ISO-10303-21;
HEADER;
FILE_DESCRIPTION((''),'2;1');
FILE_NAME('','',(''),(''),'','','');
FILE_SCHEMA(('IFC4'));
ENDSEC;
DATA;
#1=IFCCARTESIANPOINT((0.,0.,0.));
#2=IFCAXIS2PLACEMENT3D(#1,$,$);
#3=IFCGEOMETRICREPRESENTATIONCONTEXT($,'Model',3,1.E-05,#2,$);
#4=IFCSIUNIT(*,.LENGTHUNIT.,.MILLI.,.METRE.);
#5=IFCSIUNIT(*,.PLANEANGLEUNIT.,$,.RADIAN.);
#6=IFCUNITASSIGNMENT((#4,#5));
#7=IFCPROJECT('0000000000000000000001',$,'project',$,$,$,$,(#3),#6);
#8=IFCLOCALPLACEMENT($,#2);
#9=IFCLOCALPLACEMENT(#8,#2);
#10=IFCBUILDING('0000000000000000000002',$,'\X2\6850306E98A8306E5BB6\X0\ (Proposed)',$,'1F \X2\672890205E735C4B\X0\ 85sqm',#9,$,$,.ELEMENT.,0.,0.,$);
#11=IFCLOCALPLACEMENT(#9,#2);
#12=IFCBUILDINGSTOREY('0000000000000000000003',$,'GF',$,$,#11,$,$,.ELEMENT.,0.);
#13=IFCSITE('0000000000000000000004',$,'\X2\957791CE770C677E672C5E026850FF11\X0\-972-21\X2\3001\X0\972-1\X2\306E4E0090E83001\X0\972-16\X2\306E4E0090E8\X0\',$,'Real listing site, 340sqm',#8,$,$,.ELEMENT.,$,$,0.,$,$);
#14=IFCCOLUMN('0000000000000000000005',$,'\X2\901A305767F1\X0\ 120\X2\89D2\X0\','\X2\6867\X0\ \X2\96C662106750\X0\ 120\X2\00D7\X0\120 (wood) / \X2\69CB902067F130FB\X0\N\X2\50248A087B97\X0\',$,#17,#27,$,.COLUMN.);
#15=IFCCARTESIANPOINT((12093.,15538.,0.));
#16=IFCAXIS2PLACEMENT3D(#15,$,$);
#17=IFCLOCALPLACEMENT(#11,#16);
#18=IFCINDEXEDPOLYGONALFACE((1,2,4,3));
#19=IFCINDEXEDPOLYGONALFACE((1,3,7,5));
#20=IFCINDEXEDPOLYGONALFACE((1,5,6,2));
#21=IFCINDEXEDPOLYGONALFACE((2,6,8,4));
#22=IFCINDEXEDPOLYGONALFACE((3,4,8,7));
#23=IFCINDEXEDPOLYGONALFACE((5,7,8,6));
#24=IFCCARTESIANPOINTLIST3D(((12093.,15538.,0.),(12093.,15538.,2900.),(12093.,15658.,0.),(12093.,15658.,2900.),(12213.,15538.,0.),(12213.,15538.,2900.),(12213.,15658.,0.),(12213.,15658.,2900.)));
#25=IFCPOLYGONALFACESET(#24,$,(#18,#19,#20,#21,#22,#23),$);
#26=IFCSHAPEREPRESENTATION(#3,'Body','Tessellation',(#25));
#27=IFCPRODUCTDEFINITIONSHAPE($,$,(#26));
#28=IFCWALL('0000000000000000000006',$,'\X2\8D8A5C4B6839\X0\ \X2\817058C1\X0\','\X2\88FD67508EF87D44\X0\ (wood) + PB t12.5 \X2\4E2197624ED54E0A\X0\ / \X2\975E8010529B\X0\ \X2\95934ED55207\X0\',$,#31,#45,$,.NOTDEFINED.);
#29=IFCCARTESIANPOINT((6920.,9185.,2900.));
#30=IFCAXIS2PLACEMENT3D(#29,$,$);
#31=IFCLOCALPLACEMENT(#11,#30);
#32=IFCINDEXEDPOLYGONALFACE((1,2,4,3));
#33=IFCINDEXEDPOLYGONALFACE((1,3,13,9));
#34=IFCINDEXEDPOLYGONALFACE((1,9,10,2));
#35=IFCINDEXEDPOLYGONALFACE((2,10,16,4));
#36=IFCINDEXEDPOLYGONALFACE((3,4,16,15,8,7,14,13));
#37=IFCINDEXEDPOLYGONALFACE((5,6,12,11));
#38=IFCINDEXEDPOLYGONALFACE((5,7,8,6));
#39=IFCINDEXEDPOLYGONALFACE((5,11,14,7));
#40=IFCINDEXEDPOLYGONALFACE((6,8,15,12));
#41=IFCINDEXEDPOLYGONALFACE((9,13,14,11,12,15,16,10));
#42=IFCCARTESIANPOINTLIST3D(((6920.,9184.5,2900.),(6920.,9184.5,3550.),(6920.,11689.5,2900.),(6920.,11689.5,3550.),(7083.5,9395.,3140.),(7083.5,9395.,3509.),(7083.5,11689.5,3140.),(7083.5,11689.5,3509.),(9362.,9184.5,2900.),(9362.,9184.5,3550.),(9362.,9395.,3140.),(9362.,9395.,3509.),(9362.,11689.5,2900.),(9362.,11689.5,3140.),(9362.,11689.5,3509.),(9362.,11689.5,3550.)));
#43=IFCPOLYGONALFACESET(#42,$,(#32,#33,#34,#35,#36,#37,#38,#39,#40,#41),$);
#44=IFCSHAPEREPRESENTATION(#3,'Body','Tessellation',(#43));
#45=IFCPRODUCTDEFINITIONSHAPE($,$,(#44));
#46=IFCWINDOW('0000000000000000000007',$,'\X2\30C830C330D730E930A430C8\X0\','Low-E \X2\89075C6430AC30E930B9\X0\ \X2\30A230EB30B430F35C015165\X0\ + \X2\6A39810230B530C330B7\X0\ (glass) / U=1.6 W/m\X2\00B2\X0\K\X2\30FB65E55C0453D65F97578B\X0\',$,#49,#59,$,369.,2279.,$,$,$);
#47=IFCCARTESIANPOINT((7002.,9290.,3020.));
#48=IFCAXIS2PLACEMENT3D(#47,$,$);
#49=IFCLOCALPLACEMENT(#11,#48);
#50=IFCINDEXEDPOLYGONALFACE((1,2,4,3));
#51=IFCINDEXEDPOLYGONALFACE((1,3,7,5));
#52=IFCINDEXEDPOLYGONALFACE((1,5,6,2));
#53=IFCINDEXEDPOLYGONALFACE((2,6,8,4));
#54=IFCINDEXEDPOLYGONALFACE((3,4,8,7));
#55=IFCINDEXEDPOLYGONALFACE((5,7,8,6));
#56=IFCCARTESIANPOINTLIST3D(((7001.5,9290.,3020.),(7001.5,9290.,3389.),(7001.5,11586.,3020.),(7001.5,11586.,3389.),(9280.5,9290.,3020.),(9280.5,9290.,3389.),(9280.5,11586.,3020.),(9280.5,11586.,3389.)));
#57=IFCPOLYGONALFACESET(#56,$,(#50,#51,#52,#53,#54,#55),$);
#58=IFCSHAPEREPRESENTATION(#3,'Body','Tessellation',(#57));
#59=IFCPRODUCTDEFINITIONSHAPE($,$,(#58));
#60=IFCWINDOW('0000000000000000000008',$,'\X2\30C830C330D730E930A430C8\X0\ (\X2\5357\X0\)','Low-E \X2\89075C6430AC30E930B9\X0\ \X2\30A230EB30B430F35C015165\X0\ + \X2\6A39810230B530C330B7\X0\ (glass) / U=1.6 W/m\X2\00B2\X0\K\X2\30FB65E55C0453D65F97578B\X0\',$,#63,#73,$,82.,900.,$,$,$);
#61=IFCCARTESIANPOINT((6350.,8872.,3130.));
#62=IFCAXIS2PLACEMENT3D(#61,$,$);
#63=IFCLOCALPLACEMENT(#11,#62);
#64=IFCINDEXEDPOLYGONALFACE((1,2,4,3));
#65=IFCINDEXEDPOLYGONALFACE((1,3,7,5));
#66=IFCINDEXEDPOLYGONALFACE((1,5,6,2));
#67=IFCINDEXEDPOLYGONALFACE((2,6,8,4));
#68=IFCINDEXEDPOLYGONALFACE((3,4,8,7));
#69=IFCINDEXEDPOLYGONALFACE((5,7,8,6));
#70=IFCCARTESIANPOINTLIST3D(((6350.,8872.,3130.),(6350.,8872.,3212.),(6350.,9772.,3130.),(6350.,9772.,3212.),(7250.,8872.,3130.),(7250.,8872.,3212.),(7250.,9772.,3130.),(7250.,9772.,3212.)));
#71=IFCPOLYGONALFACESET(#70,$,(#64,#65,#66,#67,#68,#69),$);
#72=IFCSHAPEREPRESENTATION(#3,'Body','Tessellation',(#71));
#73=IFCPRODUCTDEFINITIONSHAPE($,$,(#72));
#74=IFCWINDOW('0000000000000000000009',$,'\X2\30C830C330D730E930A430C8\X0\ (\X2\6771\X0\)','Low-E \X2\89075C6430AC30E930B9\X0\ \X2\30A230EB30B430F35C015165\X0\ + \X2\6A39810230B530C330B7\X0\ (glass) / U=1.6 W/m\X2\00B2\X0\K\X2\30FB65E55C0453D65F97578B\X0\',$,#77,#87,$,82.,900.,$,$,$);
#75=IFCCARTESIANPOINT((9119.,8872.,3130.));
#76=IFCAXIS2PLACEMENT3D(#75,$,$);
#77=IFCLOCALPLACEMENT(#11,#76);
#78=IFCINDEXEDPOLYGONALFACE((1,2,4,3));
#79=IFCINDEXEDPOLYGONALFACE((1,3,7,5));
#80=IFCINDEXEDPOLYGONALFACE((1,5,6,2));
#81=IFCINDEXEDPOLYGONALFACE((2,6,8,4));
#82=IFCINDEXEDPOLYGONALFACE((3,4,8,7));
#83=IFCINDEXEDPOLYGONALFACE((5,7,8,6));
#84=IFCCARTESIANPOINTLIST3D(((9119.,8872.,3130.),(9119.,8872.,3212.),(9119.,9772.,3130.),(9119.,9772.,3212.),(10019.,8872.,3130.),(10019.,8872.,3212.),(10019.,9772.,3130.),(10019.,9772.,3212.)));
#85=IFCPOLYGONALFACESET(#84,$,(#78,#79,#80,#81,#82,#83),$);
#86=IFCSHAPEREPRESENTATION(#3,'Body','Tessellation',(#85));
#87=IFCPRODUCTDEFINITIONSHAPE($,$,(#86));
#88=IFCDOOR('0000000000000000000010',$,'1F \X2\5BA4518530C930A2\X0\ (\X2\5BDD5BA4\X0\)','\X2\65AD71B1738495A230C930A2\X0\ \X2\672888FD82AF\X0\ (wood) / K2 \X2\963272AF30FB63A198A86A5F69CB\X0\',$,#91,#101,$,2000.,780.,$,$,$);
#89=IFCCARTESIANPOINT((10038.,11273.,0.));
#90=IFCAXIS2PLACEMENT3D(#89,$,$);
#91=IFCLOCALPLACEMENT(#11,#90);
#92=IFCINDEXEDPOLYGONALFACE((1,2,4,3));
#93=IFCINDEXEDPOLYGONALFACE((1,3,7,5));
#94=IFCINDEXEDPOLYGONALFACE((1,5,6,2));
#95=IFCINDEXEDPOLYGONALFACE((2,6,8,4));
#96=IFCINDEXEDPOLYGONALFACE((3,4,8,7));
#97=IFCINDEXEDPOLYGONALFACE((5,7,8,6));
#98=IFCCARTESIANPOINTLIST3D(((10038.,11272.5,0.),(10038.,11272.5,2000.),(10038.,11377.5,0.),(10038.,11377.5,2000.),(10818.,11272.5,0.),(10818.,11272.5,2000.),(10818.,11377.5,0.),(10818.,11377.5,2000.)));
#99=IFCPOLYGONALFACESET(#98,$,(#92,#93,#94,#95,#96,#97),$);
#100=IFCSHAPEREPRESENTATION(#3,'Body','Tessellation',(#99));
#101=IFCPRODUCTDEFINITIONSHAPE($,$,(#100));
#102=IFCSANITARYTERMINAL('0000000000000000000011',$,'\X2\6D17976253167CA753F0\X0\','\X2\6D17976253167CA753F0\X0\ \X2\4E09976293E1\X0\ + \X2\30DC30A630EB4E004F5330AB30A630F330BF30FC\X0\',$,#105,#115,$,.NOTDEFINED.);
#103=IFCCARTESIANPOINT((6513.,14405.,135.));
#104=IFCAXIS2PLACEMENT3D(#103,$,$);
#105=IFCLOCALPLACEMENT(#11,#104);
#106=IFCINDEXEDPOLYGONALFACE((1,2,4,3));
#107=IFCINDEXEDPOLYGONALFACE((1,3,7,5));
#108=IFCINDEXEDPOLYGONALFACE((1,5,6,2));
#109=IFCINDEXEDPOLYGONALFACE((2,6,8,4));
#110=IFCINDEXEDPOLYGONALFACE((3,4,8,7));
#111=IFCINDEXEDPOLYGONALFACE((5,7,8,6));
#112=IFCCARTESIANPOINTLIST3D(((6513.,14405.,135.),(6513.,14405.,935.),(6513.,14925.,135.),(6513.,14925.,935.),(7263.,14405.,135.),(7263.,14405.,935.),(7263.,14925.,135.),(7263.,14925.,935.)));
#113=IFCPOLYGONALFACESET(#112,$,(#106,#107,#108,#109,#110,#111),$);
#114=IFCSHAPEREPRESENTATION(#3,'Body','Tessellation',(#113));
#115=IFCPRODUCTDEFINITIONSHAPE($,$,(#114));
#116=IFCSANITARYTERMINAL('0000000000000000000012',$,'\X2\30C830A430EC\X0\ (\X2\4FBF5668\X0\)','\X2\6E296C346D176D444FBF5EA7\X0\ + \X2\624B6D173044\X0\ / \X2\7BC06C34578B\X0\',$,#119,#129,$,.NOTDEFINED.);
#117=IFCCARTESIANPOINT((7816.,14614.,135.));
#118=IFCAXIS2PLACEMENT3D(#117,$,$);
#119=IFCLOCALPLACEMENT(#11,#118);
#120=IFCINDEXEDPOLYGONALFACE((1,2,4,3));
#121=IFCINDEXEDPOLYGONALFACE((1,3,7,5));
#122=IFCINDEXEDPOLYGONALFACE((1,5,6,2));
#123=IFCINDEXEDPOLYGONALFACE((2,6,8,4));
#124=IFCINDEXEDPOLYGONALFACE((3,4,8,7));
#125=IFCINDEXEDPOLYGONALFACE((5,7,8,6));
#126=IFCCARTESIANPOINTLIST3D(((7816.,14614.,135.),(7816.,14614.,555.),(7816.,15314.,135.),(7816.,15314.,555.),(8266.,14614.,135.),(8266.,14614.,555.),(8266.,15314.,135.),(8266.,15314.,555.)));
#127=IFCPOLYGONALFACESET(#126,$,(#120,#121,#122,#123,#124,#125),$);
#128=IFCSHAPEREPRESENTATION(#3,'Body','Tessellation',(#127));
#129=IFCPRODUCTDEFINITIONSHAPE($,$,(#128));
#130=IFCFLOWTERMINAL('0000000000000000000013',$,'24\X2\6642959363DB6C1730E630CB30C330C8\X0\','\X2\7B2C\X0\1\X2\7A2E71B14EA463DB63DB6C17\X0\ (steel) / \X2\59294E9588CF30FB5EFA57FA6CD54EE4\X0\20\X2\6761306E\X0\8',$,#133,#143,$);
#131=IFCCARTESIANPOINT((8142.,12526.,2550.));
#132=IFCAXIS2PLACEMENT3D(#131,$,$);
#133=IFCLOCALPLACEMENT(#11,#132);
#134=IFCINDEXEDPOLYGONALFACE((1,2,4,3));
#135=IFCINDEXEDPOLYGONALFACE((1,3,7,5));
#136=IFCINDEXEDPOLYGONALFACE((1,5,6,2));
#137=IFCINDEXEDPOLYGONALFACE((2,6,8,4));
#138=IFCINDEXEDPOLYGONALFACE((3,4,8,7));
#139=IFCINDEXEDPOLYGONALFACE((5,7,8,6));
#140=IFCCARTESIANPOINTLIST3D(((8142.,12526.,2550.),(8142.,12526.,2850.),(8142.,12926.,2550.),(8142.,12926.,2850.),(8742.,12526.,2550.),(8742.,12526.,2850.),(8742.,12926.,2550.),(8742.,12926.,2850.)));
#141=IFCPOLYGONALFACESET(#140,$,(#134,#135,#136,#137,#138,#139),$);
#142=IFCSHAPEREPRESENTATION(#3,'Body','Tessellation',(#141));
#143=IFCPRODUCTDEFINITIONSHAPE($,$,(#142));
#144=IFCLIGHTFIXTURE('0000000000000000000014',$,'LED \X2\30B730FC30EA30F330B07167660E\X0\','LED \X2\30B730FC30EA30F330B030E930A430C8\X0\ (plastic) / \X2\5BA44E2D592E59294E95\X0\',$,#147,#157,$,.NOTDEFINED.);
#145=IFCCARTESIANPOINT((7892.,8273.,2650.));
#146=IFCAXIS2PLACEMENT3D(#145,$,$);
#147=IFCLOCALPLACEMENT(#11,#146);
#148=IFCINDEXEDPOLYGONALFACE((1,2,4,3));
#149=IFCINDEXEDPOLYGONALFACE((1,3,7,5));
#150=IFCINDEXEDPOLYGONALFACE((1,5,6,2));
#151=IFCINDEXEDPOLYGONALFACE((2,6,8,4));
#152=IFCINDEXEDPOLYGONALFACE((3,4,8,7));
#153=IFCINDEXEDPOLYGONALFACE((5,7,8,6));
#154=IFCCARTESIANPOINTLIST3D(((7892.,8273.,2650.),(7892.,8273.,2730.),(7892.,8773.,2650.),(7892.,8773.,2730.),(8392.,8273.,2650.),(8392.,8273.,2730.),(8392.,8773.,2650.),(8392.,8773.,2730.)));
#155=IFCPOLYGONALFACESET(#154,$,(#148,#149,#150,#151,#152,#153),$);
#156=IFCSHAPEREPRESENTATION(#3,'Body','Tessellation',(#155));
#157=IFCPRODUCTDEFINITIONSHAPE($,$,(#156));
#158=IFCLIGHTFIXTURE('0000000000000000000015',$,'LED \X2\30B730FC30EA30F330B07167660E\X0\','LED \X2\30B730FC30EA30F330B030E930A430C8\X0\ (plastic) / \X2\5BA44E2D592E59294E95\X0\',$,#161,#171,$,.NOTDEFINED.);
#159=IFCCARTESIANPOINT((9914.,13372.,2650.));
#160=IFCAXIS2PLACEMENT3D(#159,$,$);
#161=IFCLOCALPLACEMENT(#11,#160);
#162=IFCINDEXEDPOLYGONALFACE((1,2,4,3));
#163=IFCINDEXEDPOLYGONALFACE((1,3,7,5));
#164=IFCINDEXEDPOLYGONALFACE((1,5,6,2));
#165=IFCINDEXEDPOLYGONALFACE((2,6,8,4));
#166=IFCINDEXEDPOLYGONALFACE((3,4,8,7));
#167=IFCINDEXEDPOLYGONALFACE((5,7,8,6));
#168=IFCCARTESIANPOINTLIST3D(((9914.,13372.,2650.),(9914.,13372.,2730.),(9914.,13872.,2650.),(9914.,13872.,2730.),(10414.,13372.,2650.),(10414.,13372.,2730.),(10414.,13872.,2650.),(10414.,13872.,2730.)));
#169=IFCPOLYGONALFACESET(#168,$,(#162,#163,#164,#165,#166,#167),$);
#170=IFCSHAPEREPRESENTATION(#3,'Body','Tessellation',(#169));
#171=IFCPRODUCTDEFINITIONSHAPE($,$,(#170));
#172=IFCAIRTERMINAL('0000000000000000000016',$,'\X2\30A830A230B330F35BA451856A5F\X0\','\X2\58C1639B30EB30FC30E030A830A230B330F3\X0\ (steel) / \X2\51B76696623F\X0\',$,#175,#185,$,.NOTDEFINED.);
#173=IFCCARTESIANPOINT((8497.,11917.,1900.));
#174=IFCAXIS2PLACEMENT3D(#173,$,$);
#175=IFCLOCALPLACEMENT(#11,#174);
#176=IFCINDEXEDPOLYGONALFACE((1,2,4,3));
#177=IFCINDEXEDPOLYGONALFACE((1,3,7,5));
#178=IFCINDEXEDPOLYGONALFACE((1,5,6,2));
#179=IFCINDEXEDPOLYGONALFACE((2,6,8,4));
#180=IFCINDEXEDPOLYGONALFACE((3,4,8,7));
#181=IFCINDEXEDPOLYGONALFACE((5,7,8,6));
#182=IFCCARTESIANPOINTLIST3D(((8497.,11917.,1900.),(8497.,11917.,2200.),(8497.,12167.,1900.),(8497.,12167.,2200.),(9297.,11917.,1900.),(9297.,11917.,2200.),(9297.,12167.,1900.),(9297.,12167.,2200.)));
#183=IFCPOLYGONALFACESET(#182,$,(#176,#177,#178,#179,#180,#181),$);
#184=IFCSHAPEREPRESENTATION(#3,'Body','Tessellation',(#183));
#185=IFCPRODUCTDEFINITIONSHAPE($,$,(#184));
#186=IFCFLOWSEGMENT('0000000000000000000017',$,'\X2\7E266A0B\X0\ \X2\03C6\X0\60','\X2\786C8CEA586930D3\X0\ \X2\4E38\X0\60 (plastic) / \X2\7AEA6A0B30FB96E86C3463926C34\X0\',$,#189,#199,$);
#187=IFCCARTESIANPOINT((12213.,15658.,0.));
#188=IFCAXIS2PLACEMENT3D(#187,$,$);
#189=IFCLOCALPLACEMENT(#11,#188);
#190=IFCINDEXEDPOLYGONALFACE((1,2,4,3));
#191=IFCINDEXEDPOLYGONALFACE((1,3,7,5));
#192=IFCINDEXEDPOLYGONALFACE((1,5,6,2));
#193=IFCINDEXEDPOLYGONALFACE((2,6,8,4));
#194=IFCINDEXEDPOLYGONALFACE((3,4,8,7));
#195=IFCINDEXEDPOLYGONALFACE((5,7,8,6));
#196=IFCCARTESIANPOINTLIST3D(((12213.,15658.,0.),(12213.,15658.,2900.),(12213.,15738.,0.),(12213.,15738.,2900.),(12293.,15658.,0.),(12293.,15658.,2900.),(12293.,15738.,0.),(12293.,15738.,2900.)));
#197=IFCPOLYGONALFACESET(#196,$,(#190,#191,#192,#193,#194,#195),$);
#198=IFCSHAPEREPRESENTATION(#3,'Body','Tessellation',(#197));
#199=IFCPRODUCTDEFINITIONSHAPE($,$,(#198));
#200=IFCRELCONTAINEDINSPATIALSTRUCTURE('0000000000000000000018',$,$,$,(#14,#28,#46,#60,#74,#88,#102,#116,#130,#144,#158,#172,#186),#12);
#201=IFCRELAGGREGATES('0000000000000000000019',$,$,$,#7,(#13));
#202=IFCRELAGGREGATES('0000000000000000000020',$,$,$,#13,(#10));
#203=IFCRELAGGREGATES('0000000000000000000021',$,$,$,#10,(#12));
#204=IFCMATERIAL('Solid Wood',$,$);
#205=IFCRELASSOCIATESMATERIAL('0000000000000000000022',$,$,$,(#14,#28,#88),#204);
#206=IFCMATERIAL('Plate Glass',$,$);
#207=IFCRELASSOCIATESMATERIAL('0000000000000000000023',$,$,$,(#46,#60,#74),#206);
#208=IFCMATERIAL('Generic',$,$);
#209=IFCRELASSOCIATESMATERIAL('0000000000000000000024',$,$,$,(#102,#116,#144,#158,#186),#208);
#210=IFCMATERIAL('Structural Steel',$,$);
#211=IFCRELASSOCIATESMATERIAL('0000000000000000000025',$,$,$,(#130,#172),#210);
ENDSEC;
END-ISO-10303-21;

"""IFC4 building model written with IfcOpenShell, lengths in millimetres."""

from ifc_helpers import new_model, si_unit, frame, frame_2d, origin, place, context, project, spatial, rectangle, extrude, material, element, fill, save


model = new_model("IFC4")

# Units and contexts
model_context = context("Model", 3, precision=1e-05, world=origin())
ifc_project = project(units=[si_unit("LENGTHUNIT", "METRE", prefix="MILLI"), si_unit("PLANEANGLEUNIT", "RADIAN")], contexts=[model_context])

# Site, building, storey
site_placement = place(None, origin())
site = spatial("IfcSite", under=ifc_project, at=site_placement, Name="長野県松本市桐１-972-21、972-1の一部、972-16の一部", ObjectType="Real listing site, 340sqm", CompositionType="ELEMENT", RefElevation=0.0)
building_placement = place(site_placement, origin())
building = spatial("IfcBuilding", under=site, at=building_placement, Name="桐の風の家 (Proposed)", ObjectType="1F 木造平屋 85sqm", CompositionType="ELEMENT", ElevationOfRefHeight=0.0, ElevationOfTerrain=0.0)
storey_placement = place(building_placement, origin())
storey = spatial("IfcBuildingStorey", under=building, at=storey_placement, Name="GF", CompositionType="ELEMENT", Elevation=0.0)

# Column
ifc_material_1 = material(Name="Solid Wood")
column_1_placement = place(storey_placement, frame((12093.0, 15538.0, 0.0)))
element("IfcColumn", 1, at=column_1_placement, inside=storey, material=ifc_material_1, Name="通し柱 120角", Description="桧 集成材 120×120 (wood) / 構造柱・N値計算", PredefinedType="COLUMN", context=model_context, shape_type="SweptSolid", body=[
    extrude(rectangle(XDim=120.0, YDim=120.0, at=frame_2d((60.0, 60.0))), frame((12093.0, 15538.0, 0.0)), (0.0, 0.0, 1.0), 2900.0),
])

# Wall, openings, windows
wall_1_placement = place(storey_placement, frame((6920.0, 9185.0, 2900.0)))
wall_1 = element("IfcWall", 2, at=wall_1_placement, inside=storey, material=ifc_material_1, Name="越屋根 腰壁", Description="製材軸組 (wood) + PB t12.5 両面仕上 / 非耐力 間仕切", PredefinedType="NOTDEFINED", context=model_context, shape_type="SweptSolid", body=[
    extrude(rectangle(XDim=2442.0, YDim=2505.0, at=frame_2d((1221.0, 1252.0))), frame((6920.0, 9185.0, 2900.0)), (0.0, 0.0, 1.0), 650.0),
])
opening_1_placement = place(storey_placement, frame((7002.0, 9290.0, 3020.0)))
opening_1 = element("IfcOpeningElement", 3, at=opening_1_placement, cuts=wall_1, PredefinedType="NOTDEFINED", context=model_context, shape_type="SweptSolid", body=[
    extrude(rectangle(XDim=2279.0, YDim=2296.0, at=frame_2d((1139.0, 1148.0))), frame((7002.0, 9290.0, 3020.0)), (0.0, 0.0, 1.0), 369.0),
])
opening_2_placement = place(storey_placement, frame((6350.0, 8872.0, 3130.0)))
opening_2 = element("IfcOpeningElement", 4, at=opening_2_placement, cuts=wall_1, PredefinedType="NOTDEFINED", context=model_context, shape_type="SweptSolid", body=[
    extrude(rectangle(XDim=900.0, YDim=900.0, at=frame_2d((450.0, 450.0))), frame((6350.0, 8872.0, 3130.0)), (0.0, 0.0, 1.0), 82.0),
])
opening_3_placement = place(storey_placement, frame((9119.0, 8872.0, 3130.0)))
opening_3 = element("IfcOpeningElement", 5, at=opening_3_placement, cuts=wall_1, PredefinedType="NOTDEFINED", context=model_context, shape_type="SweptSolid", body=[
    extrude(rectangle(XDim=900.0, YDim=900.0, at=frame_2d((450.0, 450.0))), frame((9119.0, 8872.0, 3130.0)), (0.0, 0.0, 1.0), 82.0),
])
ifc_material_2 = material(Name="Plate Glass")
window_1_placement = place(storey_placement, frame((7002.0, 9290.0, 3020.0)))
window_1 = element("IfcWindow", 6, at=window_1_placement, inside=storey, material=ifc_material_2, Name="トップライト", Description="Low-E 複層ガラス アルゴン封入 + 樹脂サッシ (glass) / U=1.6 W/m²K・日射取得型", OverallHeight=369.0, OverallWidth=2279.0, context=model_context, shape_type="SweptSolid", body=[
    extrude(rectangle(XDim=2279.0, YDim=2296.0, at=frame_2d((1139.0, 1148.0))), frame((7002.0, 9290.0, 3020.0)), (0.0, 0.0, 1.0), 369.0),
])
fill(opening_1, window_1)
window_2_placement = place(storey_placement, frame((6350.0, 8872.0, 3130.0)))
window_2 = element("IfcWindow", 7, at=window_2_placement, inside=storey, material=ifc_material_2, Name="トップライト (南)", Description="Low-E 複層ガラス アルゴン封入 + 樹脂サッシ (glass) / U=1.6 W/m²K・日射取得型", OverallHeight=82.0, OverallWidth=900.0, context=model_context, shape_type="SweptSolid", body=[
    extrude(rectangle(XDim=900.0, YDim=900.0, at=frame_2d((450.0, 450.0))), frame((6350.0, 8872.0, 3130.0)), (0.0, 0.0, 1.0), 82.0),
])
fill(opening_2, window_2)
window_3_placement = place(storey_placement, frame((9119.0, 8872.0, 3130.0)))
window_3 = element("IfcWindow", 8, at=window_3_placement, inside=storey, material=ifc_material_2, Name="トップライト (東)", Description="Low-E 複層ガラス アルゴン封入 + 樹脂サッシ (glass) / U=1.6 W/m²K・日射取得型", OverallHeight=82.0, OverallWidth=900.0, context=model_context, shape_type="SweptSolid", body=[
    extrude(rectangle(XDim=900.0, YDim=900.0, at=frame_2d((450.0, 450.0))), frame((9119.0, 8872.0, 3130.0)), (0.0, 0.0, 1.0), 82.0),
])
fill(opening_3, window_3)

# Door
door_placement = place(storey_placement, frame((10038.0, 11273.0, 0.0)))
element("IfcDoor", 9, at=door_placement, inside=storey, material=ifc_material_1, Name="1F 室内ドア (寝室)", Description="断熱玄関ドア 木製芯 (wood) / K2 防犯・採風機構", OverallHeight=2000.0, OverallWidth=780.0, context=model_context, shape_type="SweptSolid", body=[
    extrude(rectangle(XDim=780.0, YDim=105.0, at=frame_2d((390.0, 52.0))), frame((10038.0, 11273.0, 0.0)), (0.0, 0.0, 1.0), 2000.0),
])

# Shared definitions
ifc_material_3 = material(Name="Structural Steel")

# Sanitary terminals
ifc_material_4 = material(Name="Generic")
sanitary_terminal_1_placement = place(storey_placement, frame((6513.0, 14405.0, 135.0)))
element("IfcSanitaryTerminal", 10, at=sanitary_terminal_1_placement, inside=storey, material=ifc_material_4, Name="洗面化粧台", Description="洗面化粧台 三面鏡 + ボウル一体カウンター", PredefinedType="NOTDEFINED", context=model_context, shape_type="SweptSolid", body=[
    extrude(rectangle(XDim=750.0, YDim=520.0, at=frame_2d((375.0, 260.0))), frame((6513.0, 14405.0, 135.0)), (0.0, 0.0, 1.0), 800.0),
])
sanitary_terminal_2_placement = place(storey_placement, frame((7816.0, 14614.0, 135.0)))
element("IfcSanitaryTerminal", 11, at=sanitary_terminal_2_placement, inside=storey, material=ifc_material_4, Name="トイレ (便器)", Description="温水洗浄便座 + 手洗い / 節水型", PredefinedType="NOTDEFINED", context=model_context, shape_type="SweptSolid", body=[
    extrude(rectangle(XDim=450.0, YDim=700.0, at=frame_2d((225.0, 350.0))), frame((7816.0, 14614.0, 135.0)), (0.0, 0.0, 1.0), 420.0),
])

# Flow terminal
flow_terminal_placement = place(storey_placement, frame((8142.0, 12526.0, 2550.0)))
element("IfcFlowTerminal", 12, at=flow_terminal_placement, inside=storey, material=ifc_material_3, Name="24時間換気ユニット", Description="第1種熱交換換気 (steel) / 天井裏・建基法令20条の8", context=model_context, shape_type="SweptSolid", body=[
    extrude(rectangle(XDim=600.0, YDim=400.0, at=frame_2d((300.0, 200.0))), frame((8142.0, 12526.0, 2550.0)), (0.0, 0.0, 1.0), 300.0),
])

# Light fixtures
light_fixture_1_placement = place(storey_placement, frame((7892.0, 8273.0, 2650.0)))
element("IfcLightFixture", 13, at=light_fixture_1_placement, inside=storey, material=ifc_material_4, Name="LED シーリング照明", Description="LED シーリングライト (plastic) / 室中央天井", PredefinedType="NOTDEFINED", context=model_context, shape_type="SweptSolid", body=[
    extrude(rectangle(XDim=500.0, YDim=500.0, at=frame_2d((250.0, 250.0))), frame((7892.0, 8273.0, 2650.0)), (0.0, 0.0, 1.0), 80.0),
])
light_fixture_2_placement = place(storey_placement, frame((9914.0, 13372.0, 2650.0)))
element("IfcLightFixture", 14, at=light_fixture_2_placement, inside=storey, material=ifc_material_4, Name="LED シーリング照明", Description="LED シーリングライト (plastic) / 室中央天井", PredefinedType="NOTDEFINED", context=model_context, shape_type="SweptSolid", body=[
    extrude(rectangle(XDim=500.0, YDim=500.0, at=frame_2d((250.0, 250.0))), frame((9914.0, 13372.0, 2650.0)), (0.0, 0.0, 1.0), 80.0),
])

# Air terminal
air_terminal_placement = place(storey_placement, frame((8497.0, 11917.0, 1900.0)))
element("IfcAirTerminal", 15, at=air_terminal_placement, inside=storey, material=ifc_material_3, Name="エアコン室内機", Description="壁掛ルームエアコン (steel) / 冷暖房", PredefinedType="NOTDEFINED", context=model_context, shape_type="SweptSolid", body=[
    extrude(rectangle(XDim=800.0, YDim=250.0, at=frame_2d((400.0, 125.0))), frame((8497.0, 11917.0, 1900.0)), (0.0, 0.0, 1.0), 300.0),
])

# Flow segment
flow_segment_placement = place(storey_placement, frame((12213.0, 15658.0, 0.0)))
element("IfcFlowSegment", 16, at=flow_segment_placement, inside=storey, material=ifc_material_4, Name="縦樋 φ60", Description="硬質塩ビ 丸60 (plastic) / 竪樋・雨水排水", context=model_context, shape_type="SweptSolid", body=[
    extrude(rectangle(XDim=80.0, YDim=80.0, at=frame_2d((40.0, 40.0))), frame((12213.0, 15658.0, 0.0)), (0.0, 0.0, 1.0), 2900.0),
])

save(model, "model.ifc")
